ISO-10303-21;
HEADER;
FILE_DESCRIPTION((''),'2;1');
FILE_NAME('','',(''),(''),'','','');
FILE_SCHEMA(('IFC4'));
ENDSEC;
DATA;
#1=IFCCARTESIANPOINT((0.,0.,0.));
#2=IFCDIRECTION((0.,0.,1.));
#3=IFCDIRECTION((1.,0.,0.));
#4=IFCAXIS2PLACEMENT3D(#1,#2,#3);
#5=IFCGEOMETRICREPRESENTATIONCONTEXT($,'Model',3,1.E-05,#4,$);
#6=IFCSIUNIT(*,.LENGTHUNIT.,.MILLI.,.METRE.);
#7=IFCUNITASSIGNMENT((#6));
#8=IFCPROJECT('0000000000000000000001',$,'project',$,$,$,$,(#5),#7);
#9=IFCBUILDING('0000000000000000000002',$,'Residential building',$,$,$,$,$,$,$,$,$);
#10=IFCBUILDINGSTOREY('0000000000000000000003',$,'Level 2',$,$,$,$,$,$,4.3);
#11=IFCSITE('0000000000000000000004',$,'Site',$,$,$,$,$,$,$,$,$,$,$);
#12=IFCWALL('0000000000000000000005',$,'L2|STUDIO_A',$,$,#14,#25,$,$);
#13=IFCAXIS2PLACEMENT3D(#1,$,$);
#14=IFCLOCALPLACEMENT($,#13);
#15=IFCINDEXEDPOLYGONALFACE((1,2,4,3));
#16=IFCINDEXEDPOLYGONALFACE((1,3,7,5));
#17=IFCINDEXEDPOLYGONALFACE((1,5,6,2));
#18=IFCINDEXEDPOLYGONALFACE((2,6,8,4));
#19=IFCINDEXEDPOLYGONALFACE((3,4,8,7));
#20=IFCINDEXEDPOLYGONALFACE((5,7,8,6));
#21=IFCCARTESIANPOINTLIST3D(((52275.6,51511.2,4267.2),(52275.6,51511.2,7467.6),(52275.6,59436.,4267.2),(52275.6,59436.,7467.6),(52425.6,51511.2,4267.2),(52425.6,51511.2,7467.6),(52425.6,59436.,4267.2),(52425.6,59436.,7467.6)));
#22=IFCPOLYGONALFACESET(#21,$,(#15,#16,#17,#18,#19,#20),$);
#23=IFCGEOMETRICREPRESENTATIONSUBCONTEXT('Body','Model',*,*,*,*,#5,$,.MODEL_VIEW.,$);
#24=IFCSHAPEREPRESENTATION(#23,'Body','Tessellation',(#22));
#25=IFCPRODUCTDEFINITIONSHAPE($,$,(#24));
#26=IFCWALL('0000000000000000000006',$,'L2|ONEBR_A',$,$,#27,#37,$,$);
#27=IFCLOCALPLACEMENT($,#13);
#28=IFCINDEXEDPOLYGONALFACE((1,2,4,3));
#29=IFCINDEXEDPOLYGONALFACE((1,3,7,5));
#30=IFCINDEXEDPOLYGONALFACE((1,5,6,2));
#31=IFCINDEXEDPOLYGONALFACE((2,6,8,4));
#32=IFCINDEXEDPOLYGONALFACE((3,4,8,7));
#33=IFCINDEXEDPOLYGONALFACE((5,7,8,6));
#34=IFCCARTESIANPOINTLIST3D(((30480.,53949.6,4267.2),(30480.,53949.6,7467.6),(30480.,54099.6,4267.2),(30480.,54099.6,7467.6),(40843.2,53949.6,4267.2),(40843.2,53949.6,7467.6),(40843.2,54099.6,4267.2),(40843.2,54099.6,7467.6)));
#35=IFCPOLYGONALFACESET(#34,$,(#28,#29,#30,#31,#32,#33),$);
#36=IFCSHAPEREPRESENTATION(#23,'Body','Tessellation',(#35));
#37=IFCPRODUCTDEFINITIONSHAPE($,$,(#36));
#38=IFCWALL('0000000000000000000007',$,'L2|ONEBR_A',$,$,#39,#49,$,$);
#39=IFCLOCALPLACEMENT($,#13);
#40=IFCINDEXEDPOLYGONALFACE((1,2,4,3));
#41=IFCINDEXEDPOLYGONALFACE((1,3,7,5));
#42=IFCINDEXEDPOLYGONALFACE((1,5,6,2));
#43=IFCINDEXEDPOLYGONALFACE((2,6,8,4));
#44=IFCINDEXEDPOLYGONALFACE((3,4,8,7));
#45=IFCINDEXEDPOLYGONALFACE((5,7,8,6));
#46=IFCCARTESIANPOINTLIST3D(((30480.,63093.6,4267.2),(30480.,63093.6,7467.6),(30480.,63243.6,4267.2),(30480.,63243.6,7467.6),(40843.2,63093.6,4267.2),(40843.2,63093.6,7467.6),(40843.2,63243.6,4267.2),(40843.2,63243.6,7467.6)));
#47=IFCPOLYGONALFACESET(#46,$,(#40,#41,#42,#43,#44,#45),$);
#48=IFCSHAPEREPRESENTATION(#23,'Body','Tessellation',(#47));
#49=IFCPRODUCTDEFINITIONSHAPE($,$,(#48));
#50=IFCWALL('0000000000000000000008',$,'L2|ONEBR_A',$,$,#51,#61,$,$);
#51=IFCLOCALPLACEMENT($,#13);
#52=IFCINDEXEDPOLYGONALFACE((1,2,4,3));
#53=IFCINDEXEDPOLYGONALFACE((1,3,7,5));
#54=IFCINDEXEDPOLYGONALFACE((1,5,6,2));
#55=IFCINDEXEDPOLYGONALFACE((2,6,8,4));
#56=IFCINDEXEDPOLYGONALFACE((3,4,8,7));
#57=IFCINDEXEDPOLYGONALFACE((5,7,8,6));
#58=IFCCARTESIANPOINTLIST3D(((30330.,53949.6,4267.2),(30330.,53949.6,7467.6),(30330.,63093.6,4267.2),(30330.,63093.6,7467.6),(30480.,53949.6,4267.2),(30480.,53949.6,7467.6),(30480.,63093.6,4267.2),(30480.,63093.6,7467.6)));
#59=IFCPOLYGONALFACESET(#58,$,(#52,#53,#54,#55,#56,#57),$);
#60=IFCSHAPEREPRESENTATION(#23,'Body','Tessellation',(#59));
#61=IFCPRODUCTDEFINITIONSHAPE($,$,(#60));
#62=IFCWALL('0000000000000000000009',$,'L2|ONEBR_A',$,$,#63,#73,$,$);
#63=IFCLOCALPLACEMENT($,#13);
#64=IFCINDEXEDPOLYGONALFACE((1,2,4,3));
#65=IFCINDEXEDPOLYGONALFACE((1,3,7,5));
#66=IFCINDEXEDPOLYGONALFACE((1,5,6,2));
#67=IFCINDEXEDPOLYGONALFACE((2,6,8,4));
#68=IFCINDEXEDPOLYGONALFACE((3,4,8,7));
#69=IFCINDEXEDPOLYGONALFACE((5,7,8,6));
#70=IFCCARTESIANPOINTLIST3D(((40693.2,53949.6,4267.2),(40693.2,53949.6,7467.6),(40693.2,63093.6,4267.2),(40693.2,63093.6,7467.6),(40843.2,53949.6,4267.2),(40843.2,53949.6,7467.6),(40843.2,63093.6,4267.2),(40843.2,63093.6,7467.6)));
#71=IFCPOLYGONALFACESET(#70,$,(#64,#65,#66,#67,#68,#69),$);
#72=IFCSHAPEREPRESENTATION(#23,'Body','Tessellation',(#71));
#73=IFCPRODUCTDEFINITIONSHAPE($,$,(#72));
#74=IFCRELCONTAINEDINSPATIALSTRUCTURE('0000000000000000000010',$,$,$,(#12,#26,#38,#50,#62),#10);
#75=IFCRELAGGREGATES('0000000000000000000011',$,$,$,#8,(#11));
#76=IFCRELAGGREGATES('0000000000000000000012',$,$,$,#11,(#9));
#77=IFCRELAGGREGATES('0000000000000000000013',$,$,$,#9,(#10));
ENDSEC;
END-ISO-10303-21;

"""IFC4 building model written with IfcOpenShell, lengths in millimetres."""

from ifc_helpers import new_model, si_unit, frame, origin_with_axes, place, context, subcontext, project, spatial, indexed_curve, outline, extrude, element, save


model = new_model("IFC4")

# Units and contexts
model_context = context("Model", 3, precision=1e-05, world=origin_with_axes())
body_context = subcontext(model_context, "Body", "Model", "MODEL_VIEW")
ifc_project = project(units=[si_unit("LENGTHUNIT", "METRE", prefix="MILLI")], contexts=[model_context])

# Site, building, storey
site = spatial("IfcSite", under=ifc_project, Name="Site")
building = spatial("IfcBuilding", under=site, Name="Residential building")
storey = spatial("IfcBuildingStorey", under=building, Name="Level 2", Elevation=4.3)

# Walls
for number, where, z_axis, x_axis, name in (
    (1, (52425.6, 51511.2, 4267.2), (0.0, 0.0, 1.0), (0.0, 1.0, 0.0), "L2|STUDIO_A"),
):
    element("IfcWall", number, at=place(None, frame(where, z_axis=z_axis, x_axis=x_axis)), inside=storey, Name=name, context=body_context, shape_type="SweptSolid", body=[
        extrude(outline(indexed_curve([(0.0, 0.0), (0.0, 150.0), (7924.8, 150.0), (7924.8, 0.0), (0.0, 0.0)], self_intersect=False)), origin_with_axes(), (0.0, 0.0, 1.0), 3200.4),
    ])
for number, where, z_axis, x_axis, name in (
    (2, (30480.0, 53949.6, 4267.2), (0.0, 0.0, 1.0), (1.0, 0.0, 0.0), "L2|ONEBR_A"),
    (3, (30480.0, 63093.6, 4267.2), (0.0, 0.0, 1.0), (1.0, 0.0, 0.0), "L2|ONEBR_A"),
):
    element("IfcWall", number, at=place(None, frame(where, z_axis=z_axis, x_axis=x_axis)), inside=storey, Name=name, context=body_context, shape_type="SweptSolid", body=[
        extrude(outline(indexed_curve([(0.0, 0.0), (0.0, 150.0), (10363.2, 150.0), (10363.2, 0.0), (0.0, 0.0)], self_intersect=False)), origin_with_axes(), (0.0, 0.0, 1.0), 3200.4),
    ])
for number, where, z_axis, x_axis, name in (
    (4, (30480.0, 53949.6, 4267.2), (0.0, 0.0, 1.0), (0.0, 1.0, 0.0), "L2|ONEBR_A"),
    (5, (40843.2, 53949.6, 4267.2), (0.0, 0.0, 1.0), (0.0, 1.0, 0.0), "L2|ONEBR_A"),
):
    element("IfcWall", number, at=place(None, frame(where, z_axis=z_axis, x_axis=x_axis)), inside=storey, Name=name, context=body_context, shape_type="SweptSolid", body=[
        extrude(outline(indexed_curve([(0.0, 0.0), (0.0, 150.0), (9144.0, 150.0), (9144.0, 0.0), (0.0, 0.0)], self_intersect=False)), origin_with_axes(), (0.0, 0.0, 1.0), 3200.4),
    ])

save(model, "model.ifc")
